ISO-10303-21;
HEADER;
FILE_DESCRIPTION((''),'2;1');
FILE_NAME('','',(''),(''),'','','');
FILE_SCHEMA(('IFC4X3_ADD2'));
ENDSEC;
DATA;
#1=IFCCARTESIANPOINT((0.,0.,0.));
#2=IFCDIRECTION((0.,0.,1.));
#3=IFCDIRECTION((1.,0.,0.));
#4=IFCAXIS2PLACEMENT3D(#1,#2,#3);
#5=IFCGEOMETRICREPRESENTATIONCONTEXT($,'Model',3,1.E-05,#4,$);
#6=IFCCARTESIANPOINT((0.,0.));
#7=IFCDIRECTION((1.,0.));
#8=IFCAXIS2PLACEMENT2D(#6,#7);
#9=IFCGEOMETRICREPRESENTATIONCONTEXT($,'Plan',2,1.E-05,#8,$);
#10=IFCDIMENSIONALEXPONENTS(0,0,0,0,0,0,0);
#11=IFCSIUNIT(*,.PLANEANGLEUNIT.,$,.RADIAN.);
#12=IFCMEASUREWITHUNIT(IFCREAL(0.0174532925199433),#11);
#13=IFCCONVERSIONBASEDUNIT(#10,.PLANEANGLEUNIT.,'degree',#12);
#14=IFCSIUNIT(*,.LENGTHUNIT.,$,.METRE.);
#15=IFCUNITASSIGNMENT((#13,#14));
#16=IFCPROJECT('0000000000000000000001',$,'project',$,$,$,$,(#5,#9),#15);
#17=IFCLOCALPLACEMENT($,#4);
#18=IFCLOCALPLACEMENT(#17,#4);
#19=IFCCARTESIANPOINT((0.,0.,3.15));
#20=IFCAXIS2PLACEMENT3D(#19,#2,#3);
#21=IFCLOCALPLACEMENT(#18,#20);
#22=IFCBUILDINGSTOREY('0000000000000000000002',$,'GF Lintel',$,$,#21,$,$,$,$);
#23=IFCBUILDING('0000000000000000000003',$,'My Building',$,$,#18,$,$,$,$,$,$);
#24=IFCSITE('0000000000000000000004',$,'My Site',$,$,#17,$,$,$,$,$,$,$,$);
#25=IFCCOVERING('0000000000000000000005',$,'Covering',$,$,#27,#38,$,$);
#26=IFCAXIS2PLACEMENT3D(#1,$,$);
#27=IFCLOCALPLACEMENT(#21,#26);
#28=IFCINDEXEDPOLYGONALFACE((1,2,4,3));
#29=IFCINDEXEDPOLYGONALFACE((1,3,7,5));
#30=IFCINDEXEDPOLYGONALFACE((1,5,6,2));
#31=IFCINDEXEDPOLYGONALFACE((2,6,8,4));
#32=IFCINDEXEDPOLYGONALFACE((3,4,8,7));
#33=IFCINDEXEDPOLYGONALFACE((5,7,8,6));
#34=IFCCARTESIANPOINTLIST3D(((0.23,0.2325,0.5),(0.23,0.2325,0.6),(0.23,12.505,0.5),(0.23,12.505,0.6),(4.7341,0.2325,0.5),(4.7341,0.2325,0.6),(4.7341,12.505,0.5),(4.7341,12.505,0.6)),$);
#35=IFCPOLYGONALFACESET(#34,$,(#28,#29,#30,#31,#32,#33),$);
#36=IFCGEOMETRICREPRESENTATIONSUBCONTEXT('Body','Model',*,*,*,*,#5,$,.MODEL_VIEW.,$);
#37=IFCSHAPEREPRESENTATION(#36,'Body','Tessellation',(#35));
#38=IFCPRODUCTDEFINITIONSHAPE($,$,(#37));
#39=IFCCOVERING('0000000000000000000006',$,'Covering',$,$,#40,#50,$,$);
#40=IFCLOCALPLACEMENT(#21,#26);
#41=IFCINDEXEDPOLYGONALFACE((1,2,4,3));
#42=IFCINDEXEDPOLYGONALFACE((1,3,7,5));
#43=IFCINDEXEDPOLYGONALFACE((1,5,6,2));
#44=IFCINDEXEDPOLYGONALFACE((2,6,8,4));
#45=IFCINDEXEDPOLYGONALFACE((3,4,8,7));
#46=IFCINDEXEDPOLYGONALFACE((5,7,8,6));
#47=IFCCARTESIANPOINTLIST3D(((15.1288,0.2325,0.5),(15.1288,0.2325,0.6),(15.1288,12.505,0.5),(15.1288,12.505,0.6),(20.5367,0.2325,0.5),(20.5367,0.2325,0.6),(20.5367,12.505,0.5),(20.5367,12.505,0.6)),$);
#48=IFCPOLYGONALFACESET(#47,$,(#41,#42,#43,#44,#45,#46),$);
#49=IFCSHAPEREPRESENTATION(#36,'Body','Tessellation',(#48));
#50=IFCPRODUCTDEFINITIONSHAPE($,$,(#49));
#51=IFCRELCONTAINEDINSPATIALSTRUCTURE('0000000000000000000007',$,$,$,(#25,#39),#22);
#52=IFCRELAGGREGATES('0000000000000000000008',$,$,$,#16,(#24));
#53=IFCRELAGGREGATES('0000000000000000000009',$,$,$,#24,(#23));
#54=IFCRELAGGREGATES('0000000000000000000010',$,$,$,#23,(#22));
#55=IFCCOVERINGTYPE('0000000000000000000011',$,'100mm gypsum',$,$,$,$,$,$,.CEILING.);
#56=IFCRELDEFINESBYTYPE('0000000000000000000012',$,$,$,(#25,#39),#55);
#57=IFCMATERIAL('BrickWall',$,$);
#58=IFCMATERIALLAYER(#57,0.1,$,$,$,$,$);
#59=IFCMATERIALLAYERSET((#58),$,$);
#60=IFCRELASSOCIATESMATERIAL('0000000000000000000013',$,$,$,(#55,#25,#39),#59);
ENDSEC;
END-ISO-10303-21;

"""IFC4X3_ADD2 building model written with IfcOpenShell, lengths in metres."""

from ifc_helpers import new_model, entity, si_unit, converted_unit, frame, origin_with_axes, origin_2d_with_axis, place, context, subcontext, project, spatial, line, indexed_curve, outline, extrude, material, layer, layer_set, layer_usage, type_object, element, save


model = new_model("IFC4X3_ADD2")

# Units and contexts
model_context = context("Model", 3, precision=1e-05, world=origin_with_axes())
plan_context = context("Plan", 2, precision=1e-05, world=origin_2d_with_axis())
body_context = subcontext(model_context, "Body", "Model", "MODEL_VIEW")
ifc_project = project(units=[converted_unit("PLANEANGLEUNIT", "degree", entity("IfcReal", 0.0174532925199433), si_unit("PLANEANGLEUNIT", "RADIAN"), dimensions=[0, 0, 0, 0, 0, 0, 0]), si_unit("LENGTHUNIT", "METRE")], contexts=[model_context, plan_context])

# Site, building, storey
site_placement = place(None, origin_with_axes())
site = spatial("IfcSite", under=ifc_project, at=site_placement, Name="My Site")
building_placement = place(site_placement, origin_with_axes())
building = spatial("IfcBuilding", under=site, at=building_placement, Name="My Building")
storey_placement = place(building_placement, frame((0.0, 0.0, 3.15), z_axis=(0.0, 0.0, 1.0), x_axis=(1.0, 0.0, 0.0)))
storey = spatial("IfcBuildingStorey", under=building, at=storey_placement, Name="GF Lintel")

# Shared definitions
ifc_material = material(Name="BrickWall")

# Coverings
ifc_layer_1 = layer(ifc_material, 0.1)
ifc_layer_set_1 = layer_set([ifc_layer_1])
covering_type_1 = type_object("IfcCoveringType", Name="100mm gypsum", PredefinedType="CEILING", material=ifc_layer_set_1)
ifc_layer_usage_1 = layer_usage(ifc_layer_set_1, "AXIS3", "POSITIVE", 0.0)
covering_1_placement = place(storey_placement, frame((0.23, 12.505, 0.5), z_axis=(0.0, 0.0, 1.0), x_axis=(0.0, -1.0, 0.0)))
element("IfcCovering", 1, at=covering_1_placement, inside=storey, type_object=covering_type_1, material=ifc_layer_usage_1, Name="Covering", context=body_context, shape_type="SweptSolid", body=[
    extrude(outline(indexed_curve([(12.2725, 4.5041), (12.2725, 0.0), (0.0, 0.0), (0.0, 4.5041)], segments=[line(4, 1), line(1, 2), line(2, 3), line(3, 4)], self_intersect=False)), None, (0.0, 0.0, 1.0), 0.1),
])
ifc_layer_usage_2 = layer_usage(ifc_layer_set_1, "AXIS3", "POSITIVE", 0.0)
covering_2_placement = place(storey_placement, frame((15.1288, 12.505, 0.5), z_axis=(0.0, 0.0, 1.0), x_axis=(0.0, -1.0, 0.0)))
element("IfcCovering", 2, at=covering_2_placement, inside=storey, type_object=covering_type_1, material=ifc_layer_usage_2, Name="Covering", context=body_context, shape_type="SweptSolid", body=[
    extrude(outline(indexed_curve([(0.0, 5.4079), (12.2725, 5.4079), (12.2725, 0.0), (0.0, 0.0)], segments=[line(3, 2), line(2, 1), line(1, 4), line(4, 3)], self_intersect=False)), None, (0.0, 0.0, 1.0), 0.1),
])

save(model, "model.ifc")
